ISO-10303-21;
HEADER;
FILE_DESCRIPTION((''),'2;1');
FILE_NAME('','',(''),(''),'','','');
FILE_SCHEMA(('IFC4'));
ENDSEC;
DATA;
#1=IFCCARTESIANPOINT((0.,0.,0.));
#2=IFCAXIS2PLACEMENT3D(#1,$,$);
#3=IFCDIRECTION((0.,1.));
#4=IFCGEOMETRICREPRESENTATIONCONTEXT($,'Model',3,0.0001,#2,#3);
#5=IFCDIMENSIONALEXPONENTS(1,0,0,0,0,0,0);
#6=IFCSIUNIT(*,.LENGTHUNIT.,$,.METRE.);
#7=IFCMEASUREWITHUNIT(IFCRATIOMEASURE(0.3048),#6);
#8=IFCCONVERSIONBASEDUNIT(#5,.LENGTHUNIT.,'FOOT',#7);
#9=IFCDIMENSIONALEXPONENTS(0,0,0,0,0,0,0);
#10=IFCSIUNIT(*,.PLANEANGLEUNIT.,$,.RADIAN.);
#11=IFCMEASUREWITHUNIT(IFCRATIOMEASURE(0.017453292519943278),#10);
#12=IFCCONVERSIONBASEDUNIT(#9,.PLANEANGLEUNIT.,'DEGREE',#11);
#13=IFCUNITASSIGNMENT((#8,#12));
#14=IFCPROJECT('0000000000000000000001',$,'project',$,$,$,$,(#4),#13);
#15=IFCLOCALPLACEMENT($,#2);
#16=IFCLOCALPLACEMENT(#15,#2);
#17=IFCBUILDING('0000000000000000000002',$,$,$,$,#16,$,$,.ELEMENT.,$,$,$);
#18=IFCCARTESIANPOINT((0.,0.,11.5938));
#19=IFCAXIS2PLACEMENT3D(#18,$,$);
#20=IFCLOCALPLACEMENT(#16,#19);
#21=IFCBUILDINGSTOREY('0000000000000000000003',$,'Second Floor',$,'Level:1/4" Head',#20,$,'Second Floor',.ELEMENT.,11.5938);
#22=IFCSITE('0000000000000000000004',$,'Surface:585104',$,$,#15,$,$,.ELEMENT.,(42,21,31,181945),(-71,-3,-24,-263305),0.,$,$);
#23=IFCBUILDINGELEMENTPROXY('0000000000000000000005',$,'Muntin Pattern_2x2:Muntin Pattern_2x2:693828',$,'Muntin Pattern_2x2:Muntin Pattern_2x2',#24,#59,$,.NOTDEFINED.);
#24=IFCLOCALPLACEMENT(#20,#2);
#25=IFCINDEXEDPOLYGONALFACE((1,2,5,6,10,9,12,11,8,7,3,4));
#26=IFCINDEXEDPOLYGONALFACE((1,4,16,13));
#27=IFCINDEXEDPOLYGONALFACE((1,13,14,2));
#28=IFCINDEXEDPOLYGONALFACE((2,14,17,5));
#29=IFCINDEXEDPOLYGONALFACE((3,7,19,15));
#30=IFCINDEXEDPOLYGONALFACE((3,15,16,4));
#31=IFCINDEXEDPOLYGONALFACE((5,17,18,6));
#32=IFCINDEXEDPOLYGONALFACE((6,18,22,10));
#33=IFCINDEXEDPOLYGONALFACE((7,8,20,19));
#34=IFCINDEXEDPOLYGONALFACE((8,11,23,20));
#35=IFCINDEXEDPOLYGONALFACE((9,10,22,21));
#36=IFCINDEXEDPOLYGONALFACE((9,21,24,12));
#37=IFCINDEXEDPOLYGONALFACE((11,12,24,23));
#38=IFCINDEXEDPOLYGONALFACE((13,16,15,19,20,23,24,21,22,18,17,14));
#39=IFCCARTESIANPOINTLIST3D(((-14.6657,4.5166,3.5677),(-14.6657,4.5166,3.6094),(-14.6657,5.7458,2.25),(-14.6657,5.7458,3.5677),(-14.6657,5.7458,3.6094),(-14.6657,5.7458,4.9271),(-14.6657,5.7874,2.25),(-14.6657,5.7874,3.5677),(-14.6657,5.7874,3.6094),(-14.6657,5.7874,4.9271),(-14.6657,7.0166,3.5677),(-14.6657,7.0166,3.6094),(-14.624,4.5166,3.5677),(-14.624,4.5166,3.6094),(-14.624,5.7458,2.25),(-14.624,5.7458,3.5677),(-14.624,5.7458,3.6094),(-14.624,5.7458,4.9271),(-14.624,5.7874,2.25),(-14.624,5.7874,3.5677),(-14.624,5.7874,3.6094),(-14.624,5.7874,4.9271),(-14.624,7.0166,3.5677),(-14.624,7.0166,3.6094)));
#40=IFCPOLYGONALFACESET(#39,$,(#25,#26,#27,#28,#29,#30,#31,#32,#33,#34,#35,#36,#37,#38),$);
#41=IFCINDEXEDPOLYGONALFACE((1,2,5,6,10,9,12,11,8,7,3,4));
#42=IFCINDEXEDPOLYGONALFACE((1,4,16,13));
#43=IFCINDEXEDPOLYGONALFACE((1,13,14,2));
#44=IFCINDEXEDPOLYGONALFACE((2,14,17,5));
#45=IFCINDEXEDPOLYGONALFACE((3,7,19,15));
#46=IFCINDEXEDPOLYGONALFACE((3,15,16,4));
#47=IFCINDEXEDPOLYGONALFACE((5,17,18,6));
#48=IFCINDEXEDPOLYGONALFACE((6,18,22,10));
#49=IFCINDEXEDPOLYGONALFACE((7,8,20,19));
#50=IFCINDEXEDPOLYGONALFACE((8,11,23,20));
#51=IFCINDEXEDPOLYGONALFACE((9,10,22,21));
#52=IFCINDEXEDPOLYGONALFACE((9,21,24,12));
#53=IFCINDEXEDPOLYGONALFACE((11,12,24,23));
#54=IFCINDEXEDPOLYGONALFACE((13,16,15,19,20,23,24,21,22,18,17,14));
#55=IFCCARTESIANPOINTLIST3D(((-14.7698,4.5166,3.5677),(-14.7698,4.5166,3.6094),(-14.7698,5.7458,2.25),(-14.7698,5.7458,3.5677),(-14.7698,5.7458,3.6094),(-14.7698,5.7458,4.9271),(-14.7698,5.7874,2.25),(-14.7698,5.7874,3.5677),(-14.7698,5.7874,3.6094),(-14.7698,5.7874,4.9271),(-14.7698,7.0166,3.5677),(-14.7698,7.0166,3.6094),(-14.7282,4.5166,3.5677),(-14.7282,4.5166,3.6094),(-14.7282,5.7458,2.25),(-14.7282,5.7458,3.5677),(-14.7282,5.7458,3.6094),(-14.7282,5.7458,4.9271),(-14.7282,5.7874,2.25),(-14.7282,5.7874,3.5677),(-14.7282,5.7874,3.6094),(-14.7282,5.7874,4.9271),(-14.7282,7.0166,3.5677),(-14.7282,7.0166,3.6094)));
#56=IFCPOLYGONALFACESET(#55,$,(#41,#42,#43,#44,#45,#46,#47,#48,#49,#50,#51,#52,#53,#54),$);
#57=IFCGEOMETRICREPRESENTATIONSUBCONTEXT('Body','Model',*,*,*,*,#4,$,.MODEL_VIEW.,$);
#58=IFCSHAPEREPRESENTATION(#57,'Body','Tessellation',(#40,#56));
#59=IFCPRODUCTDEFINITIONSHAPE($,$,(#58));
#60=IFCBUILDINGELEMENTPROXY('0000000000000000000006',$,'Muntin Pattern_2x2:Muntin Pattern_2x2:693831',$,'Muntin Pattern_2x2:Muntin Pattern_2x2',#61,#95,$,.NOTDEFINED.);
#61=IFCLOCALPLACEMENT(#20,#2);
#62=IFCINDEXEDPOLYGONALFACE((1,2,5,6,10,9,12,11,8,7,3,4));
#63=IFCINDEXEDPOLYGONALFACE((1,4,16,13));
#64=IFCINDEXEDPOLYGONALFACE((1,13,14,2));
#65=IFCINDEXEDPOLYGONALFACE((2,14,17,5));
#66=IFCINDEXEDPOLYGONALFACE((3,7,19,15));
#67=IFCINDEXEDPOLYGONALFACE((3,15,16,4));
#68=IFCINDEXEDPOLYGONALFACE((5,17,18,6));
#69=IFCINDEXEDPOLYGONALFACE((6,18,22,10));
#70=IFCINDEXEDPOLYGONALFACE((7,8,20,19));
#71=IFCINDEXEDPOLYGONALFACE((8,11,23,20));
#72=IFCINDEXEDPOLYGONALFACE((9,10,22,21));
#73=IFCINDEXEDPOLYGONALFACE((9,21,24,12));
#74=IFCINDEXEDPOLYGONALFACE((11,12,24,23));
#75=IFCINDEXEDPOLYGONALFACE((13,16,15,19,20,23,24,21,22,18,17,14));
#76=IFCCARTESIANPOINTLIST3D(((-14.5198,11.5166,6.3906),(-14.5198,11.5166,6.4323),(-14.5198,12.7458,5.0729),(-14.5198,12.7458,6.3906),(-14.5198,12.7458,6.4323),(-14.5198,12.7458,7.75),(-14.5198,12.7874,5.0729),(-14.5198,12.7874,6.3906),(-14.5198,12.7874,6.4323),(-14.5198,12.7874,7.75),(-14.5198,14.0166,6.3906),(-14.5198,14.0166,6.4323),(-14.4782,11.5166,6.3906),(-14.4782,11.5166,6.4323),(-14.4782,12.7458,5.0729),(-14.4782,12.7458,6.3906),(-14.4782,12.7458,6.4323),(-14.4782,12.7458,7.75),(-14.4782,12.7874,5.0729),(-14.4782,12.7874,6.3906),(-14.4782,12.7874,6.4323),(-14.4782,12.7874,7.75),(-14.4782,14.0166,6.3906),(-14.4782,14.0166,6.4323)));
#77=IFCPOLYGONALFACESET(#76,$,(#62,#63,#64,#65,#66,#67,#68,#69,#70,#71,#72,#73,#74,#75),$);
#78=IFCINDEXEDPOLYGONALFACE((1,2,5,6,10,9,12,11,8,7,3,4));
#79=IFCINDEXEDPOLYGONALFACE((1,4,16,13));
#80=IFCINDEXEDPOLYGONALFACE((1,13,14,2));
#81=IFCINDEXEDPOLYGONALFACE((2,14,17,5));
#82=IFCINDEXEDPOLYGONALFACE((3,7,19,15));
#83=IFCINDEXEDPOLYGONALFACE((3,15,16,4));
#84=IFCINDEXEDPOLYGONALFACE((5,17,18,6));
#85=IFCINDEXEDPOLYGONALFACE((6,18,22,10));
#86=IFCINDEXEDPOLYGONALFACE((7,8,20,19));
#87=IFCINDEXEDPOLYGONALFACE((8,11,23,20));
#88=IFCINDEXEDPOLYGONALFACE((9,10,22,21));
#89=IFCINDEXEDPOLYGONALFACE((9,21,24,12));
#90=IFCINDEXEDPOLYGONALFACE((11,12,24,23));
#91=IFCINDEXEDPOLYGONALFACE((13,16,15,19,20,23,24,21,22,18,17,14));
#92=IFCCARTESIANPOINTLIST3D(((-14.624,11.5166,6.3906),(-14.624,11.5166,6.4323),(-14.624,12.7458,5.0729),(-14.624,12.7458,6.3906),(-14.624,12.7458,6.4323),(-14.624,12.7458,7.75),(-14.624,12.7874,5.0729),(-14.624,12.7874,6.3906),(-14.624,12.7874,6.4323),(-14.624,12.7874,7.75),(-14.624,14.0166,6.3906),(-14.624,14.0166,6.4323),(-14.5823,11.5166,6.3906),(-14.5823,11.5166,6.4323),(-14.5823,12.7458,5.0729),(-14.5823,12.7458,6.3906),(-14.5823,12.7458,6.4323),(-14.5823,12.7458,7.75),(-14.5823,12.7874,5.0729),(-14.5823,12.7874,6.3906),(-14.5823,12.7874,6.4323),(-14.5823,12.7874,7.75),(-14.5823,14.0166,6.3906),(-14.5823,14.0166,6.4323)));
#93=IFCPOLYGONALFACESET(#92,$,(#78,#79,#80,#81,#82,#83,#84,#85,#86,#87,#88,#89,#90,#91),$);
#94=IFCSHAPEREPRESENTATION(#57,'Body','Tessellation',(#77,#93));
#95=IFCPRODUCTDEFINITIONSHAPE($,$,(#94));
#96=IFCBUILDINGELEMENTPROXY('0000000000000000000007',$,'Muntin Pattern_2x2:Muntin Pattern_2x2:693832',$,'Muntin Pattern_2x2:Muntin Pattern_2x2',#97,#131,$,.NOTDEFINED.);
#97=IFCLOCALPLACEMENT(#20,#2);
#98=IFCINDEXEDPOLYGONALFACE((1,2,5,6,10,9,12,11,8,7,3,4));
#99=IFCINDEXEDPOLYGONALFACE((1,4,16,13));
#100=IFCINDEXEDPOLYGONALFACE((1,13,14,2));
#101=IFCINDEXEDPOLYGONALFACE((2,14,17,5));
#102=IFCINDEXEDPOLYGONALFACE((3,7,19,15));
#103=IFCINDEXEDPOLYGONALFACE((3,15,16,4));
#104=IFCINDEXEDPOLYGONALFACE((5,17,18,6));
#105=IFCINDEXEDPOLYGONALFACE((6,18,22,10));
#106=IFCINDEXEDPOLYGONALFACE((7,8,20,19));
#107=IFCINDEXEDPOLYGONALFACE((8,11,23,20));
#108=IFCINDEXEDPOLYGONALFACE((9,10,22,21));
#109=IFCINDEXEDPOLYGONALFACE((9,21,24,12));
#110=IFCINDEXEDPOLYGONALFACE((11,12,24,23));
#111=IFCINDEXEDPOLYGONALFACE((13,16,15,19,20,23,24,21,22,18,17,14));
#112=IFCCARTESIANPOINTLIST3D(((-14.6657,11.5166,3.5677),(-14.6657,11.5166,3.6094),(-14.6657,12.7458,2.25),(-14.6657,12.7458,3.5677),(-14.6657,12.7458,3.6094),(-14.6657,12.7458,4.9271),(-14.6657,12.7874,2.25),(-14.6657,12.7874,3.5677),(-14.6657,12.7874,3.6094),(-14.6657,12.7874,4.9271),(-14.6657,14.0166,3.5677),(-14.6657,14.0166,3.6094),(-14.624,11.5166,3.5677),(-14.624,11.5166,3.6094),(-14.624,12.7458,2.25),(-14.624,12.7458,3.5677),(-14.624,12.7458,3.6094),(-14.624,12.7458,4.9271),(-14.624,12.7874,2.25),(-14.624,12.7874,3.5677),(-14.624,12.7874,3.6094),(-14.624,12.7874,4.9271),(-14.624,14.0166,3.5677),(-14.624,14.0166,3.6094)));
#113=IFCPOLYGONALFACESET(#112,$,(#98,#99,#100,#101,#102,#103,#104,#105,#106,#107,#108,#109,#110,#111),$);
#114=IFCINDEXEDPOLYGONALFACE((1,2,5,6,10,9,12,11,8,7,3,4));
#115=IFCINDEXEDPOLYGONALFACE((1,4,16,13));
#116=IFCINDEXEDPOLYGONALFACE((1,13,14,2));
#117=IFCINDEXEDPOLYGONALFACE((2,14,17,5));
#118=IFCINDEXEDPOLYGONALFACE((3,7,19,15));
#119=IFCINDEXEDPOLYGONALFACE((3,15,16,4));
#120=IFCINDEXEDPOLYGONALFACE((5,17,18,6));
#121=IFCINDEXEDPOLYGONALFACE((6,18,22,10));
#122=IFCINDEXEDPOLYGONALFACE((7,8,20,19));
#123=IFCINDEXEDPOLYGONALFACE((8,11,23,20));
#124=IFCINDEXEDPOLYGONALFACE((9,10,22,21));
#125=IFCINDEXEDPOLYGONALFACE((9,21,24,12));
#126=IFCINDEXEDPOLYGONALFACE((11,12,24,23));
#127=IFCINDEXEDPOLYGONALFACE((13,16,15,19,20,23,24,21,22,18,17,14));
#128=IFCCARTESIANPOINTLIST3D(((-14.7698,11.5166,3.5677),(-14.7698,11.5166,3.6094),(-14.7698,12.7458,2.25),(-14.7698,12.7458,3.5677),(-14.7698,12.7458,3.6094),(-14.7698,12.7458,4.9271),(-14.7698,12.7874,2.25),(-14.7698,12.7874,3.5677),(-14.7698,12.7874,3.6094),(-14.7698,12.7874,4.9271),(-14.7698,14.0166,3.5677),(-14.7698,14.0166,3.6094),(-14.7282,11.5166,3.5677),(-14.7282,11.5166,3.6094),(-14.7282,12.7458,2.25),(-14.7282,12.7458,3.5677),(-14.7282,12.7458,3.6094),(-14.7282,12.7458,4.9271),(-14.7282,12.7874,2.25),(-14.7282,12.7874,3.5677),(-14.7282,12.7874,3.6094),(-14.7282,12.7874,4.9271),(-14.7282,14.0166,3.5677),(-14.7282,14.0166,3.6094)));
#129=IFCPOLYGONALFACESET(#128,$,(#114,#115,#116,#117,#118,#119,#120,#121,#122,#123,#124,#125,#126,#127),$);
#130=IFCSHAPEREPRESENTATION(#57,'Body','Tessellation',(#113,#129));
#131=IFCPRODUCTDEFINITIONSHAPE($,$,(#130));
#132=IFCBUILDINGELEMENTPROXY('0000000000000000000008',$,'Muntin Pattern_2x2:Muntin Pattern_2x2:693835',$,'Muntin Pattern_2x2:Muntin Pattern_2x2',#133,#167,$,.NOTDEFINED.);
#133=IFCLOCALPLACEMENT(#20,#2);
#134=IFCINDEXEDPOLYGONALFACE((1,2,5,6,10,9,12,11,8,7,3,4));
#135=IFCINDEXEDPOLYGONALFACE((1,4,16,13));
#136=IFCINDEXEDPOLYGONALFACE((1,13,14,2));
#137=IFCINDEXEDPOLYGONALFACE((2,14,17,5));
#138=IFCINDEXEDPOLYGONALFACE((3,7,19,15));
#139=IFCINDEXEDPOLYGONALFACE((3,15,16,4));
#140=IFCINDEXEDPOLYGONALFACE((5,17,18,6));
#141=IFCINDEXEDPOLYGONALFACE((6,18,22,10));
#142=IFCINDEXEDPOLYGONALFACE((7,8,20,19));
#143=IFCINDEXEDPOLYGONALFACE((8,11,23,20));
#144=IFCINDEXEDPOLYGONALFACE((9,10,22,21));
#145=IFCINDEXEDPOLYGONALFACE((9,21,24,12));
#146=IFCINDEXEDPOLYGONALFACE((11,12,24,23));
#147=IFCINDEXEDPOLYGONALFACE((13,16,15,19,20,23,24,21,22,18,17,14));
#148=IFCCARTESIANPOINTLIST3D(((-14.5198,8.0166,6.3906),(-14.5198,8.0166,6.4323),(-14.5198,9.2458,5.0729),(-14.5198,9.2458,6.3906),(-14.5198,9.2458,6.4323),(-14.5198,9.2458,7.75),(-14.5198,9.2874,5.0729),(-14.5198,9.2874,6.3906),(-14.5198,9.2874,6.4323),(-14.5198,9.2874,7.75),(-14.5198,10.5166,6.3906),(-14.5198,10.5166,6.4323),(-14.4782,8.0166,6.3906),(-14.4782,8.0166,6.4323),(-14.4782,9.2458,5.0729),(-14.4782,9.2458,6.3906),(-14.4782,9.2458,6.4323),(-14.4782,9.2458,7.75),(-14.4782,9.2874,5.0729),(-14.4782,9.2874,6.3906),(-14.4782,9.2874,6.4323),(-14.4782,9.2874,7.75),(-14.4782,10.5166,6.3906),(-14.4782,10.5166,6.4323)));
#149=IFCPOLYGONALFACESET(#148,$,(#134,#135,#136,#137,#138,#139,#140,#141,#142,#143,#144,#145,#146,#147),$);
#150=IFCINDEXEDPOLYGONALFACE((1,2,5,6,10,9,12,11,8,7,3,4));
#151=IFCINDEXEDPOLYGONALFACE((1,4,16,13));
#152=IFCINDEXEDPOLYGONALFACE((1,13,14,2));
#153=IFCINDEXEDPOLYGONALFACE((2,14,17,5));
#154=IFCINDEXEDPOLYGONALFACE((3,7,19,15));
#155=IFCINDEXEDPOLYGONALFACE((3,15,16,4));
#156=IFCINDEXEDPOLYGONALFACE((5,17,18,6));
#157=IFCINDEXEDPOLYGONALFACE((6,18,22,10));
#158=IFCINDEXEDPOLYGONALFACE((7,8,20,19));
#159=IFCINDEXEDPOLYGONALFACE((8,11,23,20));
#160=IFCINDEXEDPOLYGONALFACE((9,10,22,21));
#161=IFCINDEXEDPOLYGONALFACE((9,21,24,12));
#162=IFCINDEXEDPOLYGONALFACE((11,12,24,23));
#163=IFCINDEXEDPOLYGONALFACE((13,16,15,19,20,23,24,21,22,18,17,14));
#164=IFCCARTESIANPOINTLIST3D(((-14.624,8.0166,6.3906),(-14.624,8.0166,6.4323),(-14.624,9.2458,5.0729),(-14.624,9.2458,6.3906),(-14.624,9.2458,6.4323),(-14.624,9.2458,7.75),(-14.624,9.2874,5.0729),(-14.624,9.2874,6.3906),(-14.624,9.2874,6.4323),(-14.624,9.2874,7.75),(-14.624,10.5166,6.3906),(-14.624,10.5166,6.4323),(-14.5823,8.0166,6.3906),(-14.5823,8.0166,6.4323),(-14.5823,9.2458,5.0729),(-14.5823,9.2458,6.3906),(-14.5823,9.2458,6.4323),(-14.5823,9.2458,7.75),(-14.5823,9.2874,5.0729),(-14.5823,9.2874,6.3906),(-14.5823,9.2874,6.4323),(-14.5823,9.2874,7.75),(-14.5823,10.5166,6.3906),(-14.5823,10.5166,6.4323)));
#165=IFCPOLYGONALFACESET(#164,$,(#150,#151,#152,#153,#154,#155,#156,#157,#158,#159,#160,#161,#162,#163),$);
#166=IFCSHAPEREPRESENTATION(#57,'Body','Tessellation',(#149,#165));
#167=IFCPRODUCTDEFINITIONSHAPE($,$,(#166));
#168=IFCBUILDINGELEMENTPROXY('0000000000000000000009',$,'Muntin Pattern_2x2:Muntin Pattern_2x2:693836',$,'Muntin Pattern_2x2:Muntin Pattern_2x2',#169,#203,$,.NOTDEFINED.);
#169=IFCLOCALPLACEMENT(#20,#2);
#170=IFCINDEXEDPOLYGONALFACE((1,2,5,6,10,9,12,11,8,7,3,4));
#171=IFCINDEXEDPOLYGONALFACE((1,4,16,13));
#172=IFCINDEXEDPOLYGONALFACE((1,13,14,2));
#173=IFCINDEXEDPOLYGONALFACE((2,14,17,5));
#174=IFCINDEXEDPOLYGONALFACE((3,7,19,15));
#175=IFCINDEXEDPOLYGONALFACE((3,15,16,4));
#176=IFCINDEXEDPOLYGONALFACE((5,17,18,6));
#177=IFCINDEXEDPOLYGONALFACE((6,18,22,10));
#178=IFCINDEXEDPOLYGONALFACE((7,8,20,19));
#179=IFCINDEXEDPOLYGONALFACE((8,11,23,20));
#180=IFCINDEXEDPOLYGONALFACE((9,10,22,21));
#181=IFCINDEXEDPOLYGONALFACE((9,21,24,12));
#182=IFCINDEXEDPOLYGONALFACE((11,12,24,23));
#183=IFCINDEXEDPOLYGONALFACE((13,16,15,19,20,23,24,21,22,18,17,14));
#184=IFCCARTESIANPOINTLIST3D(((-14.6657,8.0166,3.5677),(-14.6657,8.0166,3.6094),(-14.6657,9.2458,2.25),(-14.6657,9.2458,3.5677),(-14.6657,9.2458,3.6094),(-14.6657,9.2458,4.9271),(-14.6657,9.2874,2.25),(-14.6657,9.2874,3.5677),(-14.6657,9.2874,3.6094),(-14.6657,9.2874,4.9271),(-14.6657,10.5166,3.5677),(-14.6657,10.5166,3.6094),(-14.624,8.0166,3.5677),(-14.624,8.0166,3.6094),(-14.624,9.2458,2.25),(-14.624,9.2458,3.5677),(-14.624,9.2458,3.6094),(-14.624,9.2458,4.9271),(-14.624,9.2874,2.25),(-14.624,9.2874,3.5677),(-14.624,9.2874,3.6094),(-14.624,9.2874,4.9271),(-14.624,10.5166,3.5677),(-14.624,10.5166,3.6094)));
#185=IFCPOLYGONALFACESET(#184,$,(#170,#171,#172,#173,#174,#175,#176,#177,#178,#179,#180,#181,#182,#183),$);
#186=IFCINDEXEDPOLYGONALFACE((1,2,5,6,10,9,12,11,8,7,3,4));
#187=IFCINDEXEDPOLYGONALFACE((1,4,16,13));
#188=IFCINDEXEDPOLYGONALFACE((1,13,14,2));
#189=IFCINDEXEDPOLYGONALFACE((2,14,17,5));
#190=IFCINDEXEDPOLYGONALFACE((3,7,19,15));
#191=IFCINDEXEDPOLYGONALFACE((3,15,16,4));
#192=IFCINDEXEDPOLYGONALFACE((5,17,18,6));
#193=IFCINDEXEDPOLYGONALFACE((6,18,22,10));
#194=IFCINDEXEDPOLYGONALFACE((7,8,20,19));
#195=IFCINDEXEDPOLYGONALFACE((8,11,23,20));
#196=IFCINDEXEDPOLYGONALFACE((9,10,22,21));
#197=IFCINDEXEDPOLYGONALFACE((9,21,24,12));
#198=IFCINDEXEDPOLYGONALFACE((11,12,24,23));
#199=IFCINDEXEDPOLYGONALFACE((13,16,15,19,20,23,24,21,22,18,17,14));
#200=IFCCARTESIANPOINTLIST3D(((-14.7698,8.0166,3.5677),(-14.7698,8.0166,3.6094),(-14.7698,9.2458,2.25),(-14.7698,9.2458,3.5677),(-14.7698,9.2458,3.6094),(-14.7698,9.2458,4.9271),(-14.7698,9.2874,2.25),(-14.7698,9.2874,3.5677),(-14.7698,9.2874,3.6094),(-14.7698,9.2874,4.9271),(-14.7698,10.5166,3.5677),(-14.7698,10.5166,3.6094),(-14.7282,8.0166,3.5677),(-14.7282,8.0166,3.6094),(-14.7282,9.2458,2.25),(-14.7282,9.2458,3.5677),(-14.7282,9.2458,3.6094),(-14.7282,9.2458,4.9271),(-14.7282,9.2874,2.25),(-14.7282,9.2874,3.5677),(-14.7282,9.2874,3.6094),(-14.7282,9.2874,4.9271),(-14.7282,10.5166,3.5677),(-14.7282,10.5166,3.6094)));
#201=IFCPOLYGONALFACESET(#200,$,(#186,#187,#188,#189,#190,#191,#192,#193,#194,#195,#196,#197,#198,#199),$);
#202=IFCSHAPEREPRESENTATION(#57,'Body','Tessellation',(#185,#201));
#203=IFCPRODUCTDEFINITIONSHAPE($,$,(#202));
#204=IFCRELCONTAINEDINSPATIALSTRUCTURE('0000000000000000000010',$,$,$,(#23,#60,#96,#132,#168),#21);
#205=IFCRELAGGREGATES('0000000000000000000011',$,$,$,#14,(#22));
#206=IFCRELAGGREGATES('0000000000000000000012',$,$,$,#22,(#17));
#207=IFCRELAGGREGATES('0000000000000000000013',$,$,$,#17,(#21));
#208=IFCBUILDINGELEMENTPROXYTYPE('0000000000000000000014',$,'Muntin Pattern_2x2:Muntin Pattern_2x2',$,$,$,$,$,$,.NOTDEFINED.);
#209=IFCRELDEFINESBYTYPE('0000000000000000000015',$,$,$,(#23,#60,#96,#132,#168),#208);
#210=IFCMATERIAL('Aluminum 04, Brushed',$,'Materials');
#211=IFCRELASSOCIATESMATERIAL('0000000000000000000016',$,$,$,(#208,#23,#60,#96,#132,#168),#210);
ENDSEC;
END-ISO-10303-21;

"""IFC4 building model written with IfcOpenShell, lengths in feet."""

from ifc_helpers import new_model, entity, si_unit, converted_unit, direction, frame, origin, place, context, subcontext, project, spatial, indexed_curve, outline, extrude, source, transform, mapped, material, type_object, type_shapes, element, save


model = new_model("IFC4")

# Units and contexts
model_context = context("Model", 3, precision=0.0001, world=origin(), true_north=direction((0.0, 1.0)))
body_context = subcontext(model_context, "Body", "Model", "MODEL_VIEW")
ifc_project = project(units=[converted_unit("LENGTHUNIT", "FOOT", entity("IfcRatioMeasure", 0.3048), si_unit("LENGTHUNIT", "METRE"), dimensions=[1, 0, 0, 0, 0, 0, 0]), converted_unit("PLANEANGLEUNIT", "DEGREE", entity("IfcRatioMeasure", 0.017453292519943278), si_unit("PLANEANGLEUNIT", "RADIAN"), dimensions=[0, 0, 0, 0, 0, 0, 0])], contexts=[model_context])

# Site, building, storey
site_placement = place(None, origin())
site = spatial("IfcSite", under=ifc_project, at=site_placement, Name="Surface:585104", CompositionType="ELEMENT", RefLatitude=(42, 21, 31, 181945), RefLongitude=(-71, -3, -24, -263305), RefElevation=0.0)
building_placement = place(site_placement, origin())
building = spatial("IfcBuilding", under=site, at=building_placement, CompositionType="ELEMENT")
storey_placement = place(building_placement, frame((0.0, 0.0, 11.5938)))
storey = spatial("IfcBuildingStorey", under=building, at=storey_placement, Name="Second Floor", ObjectType="Level:1/4\" Head", LongName="Second Floor", CompositionType="ELEMENT", Elevation=11.5938)

# Shared definitions
ifc_material_1 = material(Name="Aluminum 04, Brushed", Category="Materials")

# Building element proxies
building_element_proxy_type_1 = type_object("IfcBuildingElementProxyType", Name="Muntin Pattern_2x2:Muntin Pattern_2x2", PredefinedType="NOTDEFINED", material=ifc_material_1)
shared_shape_1 = source(origin(), body_context, "Body", "SweptSolid", [
    extrude(outline(indexed_curve([(0.0208, -0.0208), (1.3385, -0.0208), (1.3385, 0.0208), (0.0208, 0.0208), (0.0208, 1.25), (-0.0208, 1.25), (-0.0208, 0.0208), (-1.3385, 0.0208), (-1.3385, -0.0208), (-0.0208, -0.0208), (-0.0208, -1.25), (0.0208, -1.25), (0.0208, -0.0208)], self_intersect=False)), frame((0.0, -0.0729, 1.3385), z_axis=(0.0, 1.0, 0.0), x_axis=(0.0, 0.0, 1.0)), (0.0, 0.0, 1.0), 0.0417),
    extrude(outline(indexed_curve([(0.0208, -0.0208), (1.3385, -0.0208), (1.3385, 0.0208), (0.0208, 0.0208), (0.0208, 1.25), (-0.0208, 1.25), (-0.0208, 0.0208), (-1.3385, 0.0208), (-1.3385, -0.0208), (-0.0208, -0.0208), (-0.0208, -1.25), (0.0208, -1.25), (0.0208, -0.0208)], self_intersect=False)), frame((0.0, 0.0313, 1.3385), z_axis=(0.0, 1.0, 0.0), x_axis=(0.0, 0.0, 1.0)), (0.0, 0.0, 1.0), 0.0417),
])
type_shapes(building_element_proxy_type_1, [shared_shape_1])
for number, where, z_axis, x_axis, name in (
    (1, (-14.6969, 5.7666, 2.25), (0.0, 0.0, 1.0), (0.0, 1.0, 0.0), "Muntin Pattern_2x2:Muntin Pattern_2x2:693828"),
    (2, (-14.5511, 12.7666, 5.0729), (0.0, 0.0, 1.0), (0.0, 1.0, 0.0), "Muntin Pattern_2x2:Muntin Pattern_2x2:693831"),
    (3, (-14.6969, 12.7666, 2.25), (0.0, 0.0, 1.0), (0.0, 1.0, 0.0), "Muntin Pattern_2x2:Muntin Pattern_2x2:693832"),
    (4, (-14.5511, 9.2666, 5.0729), (0.0, 0.0, 1.0), (0.0, 1.0, 0.0), "Muntin Pattern_2x2:Muntin Pattern_2x2:693835"),
    (5, (-14.6969, 9.2666, 2.25), (0.0, 0.0, 1.0), (0.0, 1.0, 0.0), "Muntin Pattern_2x2:Muntin Pattern_2x2:693836"),
):
    element("IfcBuildingElementProxy", number, at=place(storey_placement, frame(where, z_axis=z_axis, x_axis=x_axis)), inside=storey, type_object=building_element_proxy_type_1, material=ifc_material_1, Name=name, ObjectType="Muntin Pattern_2x2:Muntin Pattern_2x2", PredefinedType="NOTDEFINED", context=body_context, shape_type="MappedRepresentation", body=[
        mapped(shared_shape_1, transform((0.0, 0.0, 0.0), scale=1.0)),
    ])

save(model, "model.ifc")
